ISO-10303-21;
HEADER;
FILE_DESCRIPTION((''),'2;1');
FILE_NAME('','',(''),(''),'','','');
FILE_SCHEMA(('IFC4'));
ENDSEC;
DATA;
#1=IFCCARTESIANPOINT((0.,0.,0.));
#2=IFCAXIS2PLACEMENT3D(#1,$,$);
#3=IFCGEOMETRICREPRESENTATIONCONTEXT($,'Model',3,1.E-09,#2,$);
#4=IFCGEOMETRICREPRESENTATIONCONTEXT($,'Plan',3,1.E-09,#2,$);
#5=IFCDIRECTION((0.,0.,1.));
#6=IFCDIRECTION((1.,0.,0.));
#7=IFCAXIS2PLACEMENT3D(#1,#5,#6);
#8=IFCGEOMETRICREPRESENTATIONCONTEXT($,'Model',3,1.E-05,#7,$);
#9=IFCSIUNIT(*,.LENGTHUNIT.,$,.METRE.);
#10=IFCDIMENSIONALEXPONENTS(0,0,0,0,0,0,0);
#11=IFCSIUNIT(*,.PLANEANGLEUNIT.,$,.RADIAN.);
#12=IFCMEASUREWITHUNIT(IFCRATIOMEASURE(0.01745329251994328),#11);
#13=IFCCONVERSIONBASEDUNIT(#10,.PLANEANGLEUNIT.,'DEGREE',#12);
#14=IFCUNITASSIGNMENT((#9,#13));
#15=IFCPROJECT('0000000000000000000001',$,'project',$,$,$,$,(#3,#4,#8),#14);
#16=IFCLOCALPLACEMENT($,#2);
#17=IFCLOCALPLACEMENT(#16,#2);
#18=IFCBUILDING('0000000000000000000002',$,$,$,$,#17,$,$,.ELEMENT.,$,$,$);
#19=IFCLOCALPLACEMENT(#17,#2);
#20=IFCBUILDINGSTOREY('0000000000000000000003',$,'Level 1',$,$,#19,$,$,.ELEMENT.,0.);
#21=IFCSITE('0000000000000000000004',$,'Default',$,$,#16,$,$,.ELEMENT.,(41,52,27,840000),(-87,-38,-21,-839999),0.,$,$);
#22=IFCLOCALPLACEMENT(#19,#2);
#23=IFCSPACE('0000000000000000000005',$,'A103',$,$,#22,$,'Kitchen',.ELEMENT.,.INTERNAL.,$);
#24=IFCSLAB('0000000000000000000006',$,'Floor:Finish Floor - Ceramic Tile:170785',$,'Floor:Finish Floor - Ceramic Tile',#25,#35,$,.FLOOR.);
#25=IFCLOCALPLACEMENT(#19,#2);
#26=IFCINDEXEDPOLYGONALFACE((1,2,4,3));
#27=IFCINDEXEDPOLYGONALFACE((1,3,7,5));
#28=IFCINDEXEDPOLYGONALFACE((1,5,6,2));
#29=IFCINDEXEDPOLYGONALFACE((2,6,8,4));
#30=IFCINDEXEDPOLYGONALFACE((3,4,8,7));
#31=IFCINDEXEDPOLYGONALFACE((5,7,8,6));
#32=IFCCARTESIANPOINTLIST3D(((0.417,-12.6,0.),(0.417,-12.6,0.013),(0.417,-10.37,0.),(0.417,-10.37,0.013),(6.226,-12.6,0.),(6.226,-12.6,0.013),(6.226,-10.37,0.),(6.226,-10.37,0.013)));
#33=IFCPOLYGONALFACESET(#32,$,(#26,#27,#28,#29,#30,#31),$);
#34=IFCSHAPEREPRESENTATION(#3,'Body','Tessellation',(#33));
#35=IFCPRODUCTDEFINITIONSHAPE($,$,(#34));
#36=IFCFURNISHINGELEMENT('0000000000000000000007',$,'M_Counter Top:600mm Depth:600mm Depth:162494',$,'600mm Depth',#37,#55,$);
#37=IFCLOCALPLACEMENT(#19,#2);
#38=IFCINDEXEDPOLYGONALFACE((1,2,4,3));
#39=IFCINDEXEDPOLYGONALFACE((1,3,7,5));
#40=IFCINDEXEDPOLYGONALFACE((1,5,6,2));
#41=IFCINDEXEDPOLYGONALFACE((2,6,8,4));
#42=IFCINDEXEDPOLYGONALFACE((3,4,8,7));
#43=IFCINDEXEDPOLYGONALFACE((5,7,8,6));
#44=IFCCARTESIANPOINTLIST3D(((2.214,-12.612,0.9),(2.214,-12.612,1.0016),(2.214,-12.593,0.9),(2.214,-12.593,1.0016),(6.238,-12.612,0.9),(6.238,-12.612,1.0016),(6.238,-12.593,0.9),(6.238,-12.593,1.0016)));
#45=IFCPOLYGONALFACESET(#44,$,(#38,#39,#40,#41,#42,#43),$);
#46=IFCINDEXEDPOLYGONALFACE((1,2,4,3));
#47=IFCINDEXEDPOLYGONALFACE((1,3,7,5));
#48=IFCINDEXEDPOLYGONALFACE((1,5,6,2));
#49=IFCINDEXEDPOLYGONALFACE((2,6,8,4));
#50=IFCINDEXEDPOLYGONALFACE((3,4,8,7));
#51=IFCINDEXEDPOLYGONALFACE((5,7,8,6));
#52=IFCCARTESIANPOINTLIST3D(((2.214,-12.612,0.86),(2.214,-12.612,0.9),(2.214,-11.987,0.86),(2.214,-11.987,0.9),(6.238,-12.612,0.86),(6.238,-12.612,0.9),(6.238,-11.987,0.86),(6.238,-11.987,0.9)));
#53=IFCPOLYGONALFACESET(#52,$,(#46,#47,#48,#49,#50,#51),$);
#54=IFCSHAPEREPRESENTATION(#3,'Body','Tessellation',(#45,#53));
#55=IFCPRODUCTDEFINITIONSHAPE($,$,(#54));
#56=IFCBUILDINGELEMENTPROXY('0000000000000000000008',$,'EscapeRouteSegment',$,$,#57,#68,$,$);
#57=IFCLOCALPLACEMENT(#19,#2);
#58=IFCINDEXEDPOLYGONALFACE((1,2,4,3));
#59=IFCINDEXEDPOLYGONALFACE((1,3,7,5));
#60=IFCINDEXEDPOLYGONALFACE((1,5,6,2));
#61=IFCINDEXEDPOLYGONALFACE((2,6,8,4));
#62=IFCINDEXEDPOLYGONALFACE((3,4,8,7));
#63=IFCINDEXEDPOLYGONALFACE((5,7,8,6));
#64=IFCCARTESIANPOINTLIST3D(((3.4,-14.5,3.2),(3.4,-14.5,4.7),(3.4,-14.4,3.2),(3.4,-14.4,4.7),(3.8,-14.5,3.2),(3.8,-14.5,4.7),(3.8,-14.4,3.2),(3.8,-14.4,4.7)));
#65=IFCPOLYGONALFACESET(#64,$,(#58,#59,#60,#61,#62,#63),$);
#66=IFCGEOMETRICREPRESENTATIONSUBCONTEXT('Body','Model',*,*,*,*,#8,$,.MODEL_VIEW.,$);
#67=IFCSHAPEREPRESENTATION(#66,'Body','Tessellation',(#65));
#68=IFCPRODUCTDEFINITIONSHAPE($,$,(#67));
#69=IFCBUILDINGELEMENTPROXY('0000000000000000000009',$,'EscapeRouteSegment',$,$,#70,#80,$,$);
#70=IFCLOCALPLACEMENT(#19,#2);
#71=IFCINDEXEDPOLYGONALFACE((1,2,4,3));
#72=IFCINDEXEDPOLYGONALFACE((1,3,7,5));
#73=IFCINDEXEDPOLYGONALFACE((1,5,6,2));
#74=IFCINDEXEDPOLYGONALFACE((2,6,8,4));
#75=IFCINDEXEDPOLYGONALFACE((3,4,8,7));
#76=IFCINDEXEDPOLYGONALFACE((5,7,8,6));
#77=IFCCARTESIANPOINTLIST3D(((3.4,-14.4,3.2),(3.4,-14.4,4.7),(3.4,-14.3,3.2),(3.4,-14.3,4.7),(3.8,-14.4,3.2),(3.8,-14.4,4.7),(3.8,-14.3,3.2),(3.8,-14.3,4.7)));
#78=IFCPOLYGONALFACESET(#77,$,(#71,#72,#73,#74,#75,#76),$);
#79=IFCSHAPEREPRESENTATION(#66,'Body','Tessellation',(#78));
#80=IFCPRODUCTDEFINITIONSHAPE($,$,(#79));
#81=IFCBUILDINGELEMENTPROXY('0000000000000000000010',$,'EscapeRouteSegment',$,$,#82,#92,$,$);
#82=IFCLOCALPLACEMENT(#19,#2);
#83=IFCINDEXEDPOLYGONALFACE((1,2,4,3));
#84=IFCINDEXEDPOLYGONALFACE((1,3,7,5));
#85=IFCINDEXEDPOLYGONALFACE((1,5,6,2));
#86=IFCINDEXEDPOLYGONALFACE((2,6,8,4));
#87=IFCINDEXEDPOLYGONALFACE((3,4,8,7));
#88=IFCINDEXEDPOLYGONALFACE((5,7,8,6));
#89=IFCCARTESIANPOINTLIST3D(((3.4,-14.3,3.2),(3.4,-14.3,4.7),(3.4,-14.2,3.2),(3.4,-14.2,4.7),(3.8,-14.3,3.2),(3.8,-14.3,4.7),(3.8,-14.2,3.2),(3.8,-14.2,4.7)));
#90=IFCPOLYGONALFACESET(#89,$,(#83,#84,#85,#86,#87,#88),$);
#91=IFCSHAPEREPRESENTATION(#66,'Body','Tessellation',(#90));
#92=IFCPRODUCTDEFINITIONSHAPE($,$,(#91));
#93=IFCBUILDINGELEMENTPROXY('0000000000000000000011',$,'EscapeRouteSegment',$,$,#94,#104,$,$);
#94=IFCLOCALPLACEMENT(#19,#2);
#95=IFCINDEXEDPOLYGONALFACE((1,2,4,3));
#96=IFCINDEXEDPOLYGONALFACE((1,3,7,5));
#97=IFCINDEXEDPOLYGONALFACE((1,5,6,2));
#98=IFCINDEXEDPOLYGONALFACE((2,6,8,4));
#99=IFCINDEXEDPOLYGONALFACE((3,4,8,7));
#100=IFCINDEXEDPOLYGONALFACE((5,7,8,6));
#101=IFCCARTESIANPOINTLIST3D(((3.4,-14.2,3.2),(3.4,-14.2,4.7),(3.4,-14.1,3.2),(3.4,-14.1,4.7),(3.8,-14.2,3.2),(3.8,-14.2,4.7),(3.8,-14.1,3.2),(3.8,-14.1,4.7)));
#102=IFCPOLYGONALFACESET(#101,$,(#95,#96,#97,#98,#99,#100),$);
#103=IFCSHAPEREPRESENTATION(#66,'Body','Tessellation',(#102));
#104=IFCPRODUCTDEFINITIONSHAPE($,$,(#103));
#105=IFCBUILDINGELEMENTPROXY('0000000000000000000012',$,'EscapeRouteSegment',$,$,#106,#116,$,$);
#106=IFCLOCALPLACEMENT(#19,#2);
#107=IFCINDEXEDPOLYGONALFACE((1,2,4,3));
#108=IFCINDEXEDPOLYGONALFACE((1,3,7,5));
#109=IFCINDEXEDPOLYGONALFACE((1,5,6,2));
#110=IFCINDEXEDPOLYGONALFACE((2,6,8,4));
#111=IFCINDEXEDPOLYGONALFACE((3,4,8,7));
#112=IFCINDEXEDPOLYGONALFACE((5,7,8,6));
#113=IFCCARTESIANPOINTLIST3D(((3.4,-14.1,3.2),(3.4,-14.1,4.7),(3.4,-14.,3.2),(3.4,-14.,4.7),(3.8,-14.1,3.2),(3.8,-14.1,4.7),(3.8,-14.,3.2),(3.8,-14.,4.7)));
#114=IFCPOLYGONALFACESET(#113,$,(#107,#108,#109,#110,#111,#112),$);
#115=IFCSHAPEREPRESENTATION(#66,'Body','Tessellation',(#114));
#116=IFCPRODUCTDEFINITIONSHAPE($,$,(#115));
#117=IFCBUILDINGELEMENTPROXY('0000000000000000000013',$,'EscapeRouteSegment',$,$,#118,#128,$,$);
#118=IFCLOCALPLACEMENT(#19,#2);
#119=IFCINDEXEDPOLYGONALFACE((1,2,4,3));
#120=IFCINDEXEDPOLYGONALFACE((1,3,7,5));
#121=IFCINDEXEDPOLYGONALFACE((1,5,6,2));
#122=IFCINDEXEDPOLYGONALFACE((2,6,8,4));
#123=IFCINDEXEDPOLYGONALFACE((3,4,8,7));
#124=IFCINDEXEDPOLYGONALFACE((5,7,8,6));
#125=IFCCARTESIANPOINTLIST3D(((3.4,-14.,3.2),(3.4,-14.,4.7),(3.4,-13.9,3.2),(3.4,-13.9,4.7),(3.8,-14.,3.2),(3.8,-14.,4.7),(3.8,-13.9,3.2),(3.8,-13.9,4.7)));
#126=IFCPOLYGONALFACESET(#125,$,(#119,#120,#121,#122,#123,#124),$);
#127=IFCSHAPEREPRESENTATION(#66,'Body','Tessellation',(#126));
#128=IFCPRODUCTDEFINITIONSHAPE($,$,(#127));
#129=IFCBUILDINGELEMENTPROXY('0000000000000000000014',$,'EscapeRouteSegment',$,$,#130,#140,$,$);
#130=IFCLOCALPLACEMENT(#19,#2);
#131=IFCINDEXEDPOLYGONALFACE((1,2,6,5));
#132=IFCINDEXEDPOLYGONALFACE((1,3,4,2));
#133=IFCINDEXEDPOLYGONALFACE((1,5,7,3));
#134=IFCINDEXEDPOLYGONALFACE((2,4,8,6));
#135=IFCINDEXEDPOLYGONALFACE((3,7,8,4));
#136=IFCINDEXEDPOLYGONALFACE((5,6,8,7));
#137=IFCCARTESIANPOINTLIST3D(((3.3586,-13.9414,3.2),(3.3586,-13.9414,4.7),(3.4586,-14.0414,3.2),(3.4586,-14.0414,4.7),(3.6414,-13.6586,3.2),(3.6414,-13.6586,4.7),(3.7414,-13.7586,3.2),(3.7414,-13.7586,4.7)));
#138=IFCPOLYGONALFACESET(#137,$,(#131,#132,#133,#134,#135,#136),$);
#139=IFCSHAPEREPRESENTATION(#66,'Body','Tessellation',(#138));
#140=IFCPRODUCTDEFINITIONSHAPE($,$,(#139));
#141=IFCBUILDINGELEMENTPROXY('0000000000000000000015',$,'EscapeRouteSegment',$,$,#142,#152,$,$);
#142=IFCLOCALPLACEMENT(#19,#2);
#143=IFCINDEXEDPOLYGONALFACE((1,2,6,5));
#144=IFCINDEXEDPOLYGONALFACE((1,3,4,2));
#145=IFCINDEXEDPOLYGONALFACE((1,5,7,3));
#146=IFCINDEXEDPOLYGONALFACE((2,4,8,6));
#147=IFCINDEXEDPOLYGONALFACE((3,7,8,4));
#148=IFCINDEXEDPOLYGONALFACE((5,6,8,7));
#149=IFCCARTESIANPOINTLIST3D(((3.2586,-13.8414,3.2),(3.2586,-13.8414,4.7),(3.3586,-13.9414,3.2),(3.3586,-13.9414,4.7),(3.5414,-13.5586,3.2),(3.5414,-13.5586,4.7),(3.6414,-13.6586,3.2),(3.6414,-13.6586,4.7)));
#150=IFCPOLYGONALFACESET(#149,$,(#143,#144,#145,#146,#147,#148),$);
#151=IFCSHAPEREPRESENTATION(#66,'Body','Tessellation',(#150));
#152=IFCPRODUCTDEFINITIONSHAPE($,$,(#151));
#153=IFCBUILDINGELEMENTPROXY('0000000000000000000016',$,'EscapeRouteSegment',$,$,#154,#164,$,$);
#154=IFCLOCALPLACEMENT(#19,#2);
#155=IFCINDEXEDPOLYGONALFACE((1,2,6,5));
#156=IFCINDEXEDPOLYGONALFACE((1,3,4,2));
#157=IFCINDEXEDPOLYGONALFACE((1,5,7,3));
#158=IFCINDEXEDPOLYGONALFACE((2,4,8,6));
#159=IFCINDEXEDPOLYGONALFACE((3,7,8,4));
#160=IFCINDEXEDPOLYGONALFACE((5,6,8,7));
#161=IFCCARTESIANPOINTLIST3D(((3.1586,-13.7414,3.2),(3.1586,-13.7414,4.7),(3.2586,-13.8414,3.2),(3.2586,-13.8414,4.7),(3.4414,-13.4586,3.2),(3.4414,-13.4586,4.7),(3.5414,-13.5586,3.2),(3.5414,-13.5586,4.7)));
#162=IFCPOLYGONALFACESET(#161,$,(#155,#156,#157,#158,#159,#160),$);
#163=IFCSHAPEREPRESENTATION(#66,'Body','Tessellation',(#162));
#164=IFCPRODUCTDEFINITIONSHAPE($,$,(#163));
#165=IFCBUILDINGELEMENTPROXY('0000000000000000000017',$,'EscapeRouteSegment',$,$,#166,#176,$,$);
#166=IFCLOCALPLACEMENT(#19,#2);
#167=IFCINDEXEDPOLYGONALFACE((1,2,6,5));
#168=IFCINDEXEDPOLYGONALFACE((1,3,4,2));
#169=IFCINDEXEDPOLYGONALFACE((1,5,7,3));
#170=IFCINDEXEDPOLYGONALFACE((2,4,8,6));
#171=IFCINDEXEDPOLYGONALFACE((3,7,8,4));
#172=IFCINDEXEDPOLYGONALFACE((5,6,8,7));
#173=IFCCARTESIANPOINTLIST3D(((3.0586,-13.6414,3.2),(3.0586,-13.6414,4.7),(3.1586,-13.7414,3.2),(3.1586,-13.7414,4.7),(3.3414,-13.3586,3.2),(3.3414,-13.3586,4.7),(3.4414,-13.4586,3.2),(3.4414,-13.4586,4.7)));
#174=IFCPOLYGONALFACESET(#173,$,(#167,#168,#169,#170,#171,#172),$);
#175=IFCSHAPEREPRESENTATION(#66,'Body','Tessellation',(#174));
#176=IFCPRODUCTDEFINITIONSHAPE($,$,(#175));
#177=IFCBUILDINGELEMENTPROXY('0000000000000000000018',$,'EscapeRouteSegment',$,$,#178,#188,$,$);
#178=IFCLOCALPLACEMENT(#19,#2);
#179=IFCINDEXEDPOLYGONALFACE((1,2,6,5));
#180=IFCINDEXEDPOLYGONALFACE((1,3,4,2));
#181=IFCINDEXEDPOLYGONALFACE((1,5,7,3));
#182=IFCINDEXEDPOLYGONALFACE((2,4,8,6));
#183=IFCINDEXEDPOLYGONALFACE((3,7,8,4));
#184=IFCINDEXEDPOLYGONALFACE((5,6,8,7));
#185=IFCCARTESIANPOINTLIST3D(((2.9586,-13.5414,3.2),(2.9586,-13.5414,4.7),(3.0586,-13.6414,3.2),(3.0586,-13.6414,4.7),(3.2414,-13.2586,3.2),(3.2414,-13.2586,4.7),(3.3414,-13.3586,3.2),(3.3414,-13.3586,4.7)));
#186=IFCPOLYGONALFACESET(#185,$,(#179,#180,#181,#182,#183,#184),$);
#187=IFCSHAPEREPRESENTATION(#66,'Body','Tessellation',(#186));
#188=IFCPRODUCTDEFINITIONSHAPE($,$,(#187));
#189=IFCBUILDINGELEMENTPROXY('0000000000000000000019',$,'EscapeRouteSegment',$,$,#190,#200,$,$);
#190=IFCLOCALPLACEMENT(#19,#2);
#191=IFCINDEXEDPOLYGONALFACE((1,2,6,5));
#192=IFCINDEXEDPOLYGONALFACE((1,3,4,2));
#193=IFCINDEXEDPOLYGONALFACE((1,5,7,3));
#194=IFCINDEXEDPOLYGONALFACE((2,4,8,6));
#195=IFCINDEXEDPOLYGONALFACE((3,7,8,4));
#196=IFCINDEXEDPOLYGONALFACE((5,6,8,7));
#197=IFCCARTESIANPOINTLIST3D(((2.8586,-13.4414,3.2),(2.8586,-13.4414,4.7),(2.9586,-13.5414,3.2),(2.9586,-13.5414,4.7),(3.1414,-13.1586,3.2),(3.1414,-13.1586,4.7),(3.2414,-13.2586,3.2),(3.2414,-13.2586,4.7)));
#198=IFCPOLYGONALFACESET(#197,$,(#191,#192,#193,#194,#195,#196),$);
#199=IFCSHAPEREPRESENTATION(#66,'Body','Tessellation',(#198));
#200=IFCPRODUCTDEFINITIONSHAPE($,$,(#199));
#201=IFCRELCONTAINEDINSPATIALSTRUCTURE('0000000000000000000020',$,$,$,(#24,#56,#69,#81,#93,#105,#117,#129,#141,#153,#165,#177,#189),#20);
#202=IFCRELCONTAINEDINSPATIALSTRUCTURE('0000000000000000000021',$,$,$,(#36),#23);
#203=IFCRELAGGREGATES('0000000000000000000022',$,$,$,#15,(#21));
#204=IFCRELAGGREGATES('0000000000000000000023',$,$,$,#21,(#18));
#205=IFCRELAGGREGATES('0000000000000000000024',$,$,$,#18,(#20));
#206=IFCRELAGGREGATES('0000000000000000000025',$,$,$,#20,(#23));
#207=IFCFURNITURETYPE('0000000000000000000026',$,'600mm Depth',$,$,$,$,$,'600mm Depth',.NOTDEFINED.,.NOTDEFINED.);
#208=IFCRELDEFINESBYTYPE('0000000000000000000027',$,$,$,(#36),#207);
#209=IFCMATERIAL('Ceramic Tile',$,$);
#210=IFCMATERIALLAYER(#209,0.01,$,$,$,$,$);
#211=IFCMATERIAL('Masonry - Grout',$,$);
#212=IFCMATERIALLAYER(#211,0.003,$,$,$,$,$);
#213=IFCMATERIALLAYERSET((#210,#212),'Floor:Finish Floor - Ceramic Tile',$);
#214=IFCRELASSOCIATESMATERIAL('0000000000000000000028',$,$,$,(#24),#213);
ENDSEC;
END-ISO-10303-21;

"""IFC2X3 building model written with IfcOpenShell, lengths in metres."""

from ifc_helpers import new_model, entity, si_unit, converted_unit, frame, frame_2d, origin, origin_with_axes, origin_2d_with_axis, place, context, subcontext, project, spatial, polyline, rectangle, outline, extrude, source, transform, mapped, material, layer, layer_set, layer_usage, type_object, type_shapes, element, save


model = new_model("IFC2X3")

# Units and contexts
model_context_1 = context("Model", 3, precision=1e-09, world=origin())
plan_context = context("Plan", 3, precision=1e-09, world=origin())
model_context_2 = context("Model", 3, precision=1e-05, world=origin_with_axes())
body_context = subcontext(model_context_2, "Body", "Model", "MODEL_VIEW")
ifc_project = project(units=[si_unit("LENGTHUNIT", "METRE"), converted_unit("PLANEANGLEUNIT", "DEGREE", entity("IfcRatioMeasure", 0.01745329251994328), si_unit("PLANEANGLEUNIT", "RADIAN"), dimensions=[0, 0, 0, 0, 0, 0, 0])], contexts=[model_context_1, plan_context, model_context_2])

# Site, building, storey
site_placement = place(None, origin())
site = spatial("IfcSite", under=ifc_project, at=site_placement, Name="Default", CompositionType="ELEMENT", RefLatitude=(41, 52, 27, 840000), RefLongitude=(-87, -38, -21, -839999), RefElevation=0.0)
building_placement = place(site_placement, origin())
building = spatial("IfcBuilding", under=site, at=building_placement, CompositionType="ELEMENT")
storey_placement = place(building_placement, origin())
storey = spatial("IfcBuildingStorey", under=building, at=storey_placement, Name="Level 1", CompositionType="ELEMENT", Elevation=0.0)

# Slab
ifc_material_1 = material(Name="Ceramic Tile")
ifc_layer_1 = layer(ifc_material_1, 0.01)
ifc_material_2 = material(Name="Masonry - Grout")
ifc_layer_2 = layer(ifc_material_2, 0.003)
ifc_layer_set = layer_set([ifc_layer_1, ifc_layer_2], Name="Floor:Finish Floor - Ceramic Tile")
ifc_layer_usage = layer_usage(ifc_layer_set, "AXIS3", "POSITIVE", 0.0)
slab_placement = place(storey_placement, frame((0.417, -12.6, 0.0)))
element("IfcSlab", 1, at=slab_placement, inside=storey, material=ifc_layer_usage, Name="Floor:Finish Floor - Ceramic Tile:170785", ObjectType="Floor:Finish Floor - Ceramic Tile", PredefinedType="FLOOR", context=model_context_1, shape_type="SweptSolid", body=[
    extrude(rectangle(XDim=5.809, YDim=2.23, at=frame_2d((0.0, 0.0), x_axis=(-1.0, 0.0))), frame((2.9045, 1.115, 0.013), z_axis=(0.0, 0.0, -1.0), x_axis=(-1.0, 0.0, 0.0)), (0.0, 0.0, 1.0), 0.013),
])

# Shared definitions
space_1_placement = place(storey_placement, origin())
space_1 = spatial("IfcSpace", under=storey, at=space_1_placement, Name="A103", LongName="Kitchen", CompositionType="ELEMENT", InteriorOrExteriorSpace="INTERNAL")

# Furnishing element
furniture_type_1 = type_object("IfcFurnitureType", Name="600mm Depth", ElementType="600mm Depth", AssemblyPlace="NOTDEFINED")
shared_shape_1 = source(origin(), model_context_1, "Body", "SweptSolid", [
    extrude(rectangle(XDim=0.0191, YDim=4.024, at=origin_2d_with_axis()), frame((0.8115, -0.0095, 0.9), z_axis=(0.0, 0.0, 1.0), x_axis=(0.0, -1.0, 0.0)), (0.0, 0.0, 1.0), 0.1016),
    extrude(rectangle(XDim=4.024, YDim=0.625, at=origin_2d_with_axis()), frame((0.8115, -0.3125, 0.86), z_axis=(0.0, 0.0, 1.0), x_axis=(-1.0, 0.0, 0.0)), (0.0, 0.0, 1.0), 0.04),
])
type_shapes(furniture_type_1, [shared_shape_1])
furnishing_1_placement = place(space_1_placement, frame((5.0375, -12.612, 0.0), z_axis=(0.0, 0.0, 1.0), x_axis=(-1.0, 0.0, 0.0)))
element("IfcFurnishingElement", 2, at=furnishing_1_placement, inside=space_1, type_object=furniture_type_1, Name="M_Counter Top:600mm Depth:600mm Depth:162494", ObjectType="600mm Depth", context=model_context_1, shape_type="MappedRepresentation", body=[
    mapped(shared_shape_1, transform((0.0, 0.0, 0.0), scale=1.0)),
])

# Building element proxies
proxy_1_placement = place(storey_placement, frame((3.6, -14.5, 3.2), z_axis=(0.0, 0.0, 1.0), x_axis=(0.0, 1.0, 0.0)))
element("IfcBuildingElementProxy", 3, at=proxy_1_placement, inside=storey, Name="EscapeRouteSegment", context=body_context, shape_type="SweptSolid", body=[
    extrude(outline(polyline([(0.0, -0.2), (0.0, 0.2), (0.1, 0.2), (0.1, -0.2), (0.0, -0.2)])), origin_with_axes(), (0.0, 0.0, 1.0), 1.5),
])
proxy_2_placement = place(storey_placement, frame((3.6, -14.4, 3.2), z_axis=(0.0, 0.0, 1.0), x_axis=(0.0, 1.0, 0.0)))
element("IfcBuildingElementProxy", 4, at=proxy_2_placement, inside=storey, Name="EscapeRouteSegment", context=body_context, shape_type="SweptSolid", body=[
    extrude(outline(polyline([(0.0, -0.2), (0.0, 0.2), (0.1, 0.2), (0.1, -0.2), (0.0, -0.2)])), origin_with_axes(), (0.0, 0.0, 1.0), 1.5),
])
proxy_3_placement = place(storey_placement, frame((3.6, -14.3, 3.2), z_axis=(0.0, 0.0, 1.0), x_axis=(0.0, 1.0, 0.0)))
element("IfcBuildingElementProxy", 5, at=proxy_3_placement, inside=storey, Name="EscapeRouteSegment", context=body_context, shape_type="SweptSolid", body=[
    extrude(outline(polyline([(0.0, -0.2), (0.0, 0.2), (0.1, 0.2), (0.1, -0.2), (0.0, -0.2)])), origin_with_axes(), (0.0, 0.0, 1.0), 1.5),
])
proxy_4_placement = place(storey_placement, frame((3.6, -14.2, 3.2), z_axis=(0.0, 0.0, 1.0), x_axis=(0.0, 1.0, 0.0)))
element("IfcBuildingElementProxy", 6, at=proxy_4_placement, inside=storey, Name="EscapeRouteSegment", context=body_context, shape_type="SweptSolid", body=[
    extrude(outline(polyline([(0.0, -0.2), (0.0, 0.2), (0.1, 0.2), (0.1, -0.2), (0.0, -0.2)])), origin_with_axes(), (0.0, 0.0, 1.0), 1.5),
])
for number, where, z_axis, x_axis, name in (
    (7, (3.6, -14.1, 3.2), (0.0, 0.0, 1.0), (0.0, 1.0, 0.0), "EscapeRouteSegment"),
    (8, (3.6, -14.0, 3.2), (0.0, 0.0, 1.0), (0.0, 1.0, 0.0), "EscapeRouteSegment"),
):
    element("IfcBuildingElementProxy", number, at=place(storey_placement, frame(where, z_axis=z_axis, x_axis=x_axis)), inside=storey, Name=name, context=body_context, shape_type="SweptSolid", body=[
        extrude(outline(polyline([(0.0, -0.2), (0.0, 0.2), (0.1, 0.2), (0.1, -0.2), (0.0, -0.2)])), origin_with_axes(), (0.0, 0.0, 1.0), 1.5),
    ])
proxy_5_placement = place(storey_placement, frame((3.6, -13.9, 3.2), z_axis=(0.0, 0.0, 1.0), x_axis=(-0.707108, 0.707105, 0.0)))
element("IfcBuildingElementProxy", 9, at=proxy_5_placement, inside=storey, Name="EscapeRouteSegment", context=body_context, shape_type="SweptSolid", body=[
    extrude(outline(polyline([(0.0, -0.2), (0.0, 0.2), (0.1414, 0.2), (0.1414, -0.2), (0.0, -0.2)])), origin_with_axes(), (0.0, 0.0, 1.0), 1.5),
])
proxy_6_placement = place(storey_placement, frame((3.5, -13.8, 3.2), z_axis=(0.0, 0.0, 1.0), x_axis=(-0.707105, 0.707108, 0.0)))
element("IfcBuildingElementProxy", 10, at=proxy_6_placement, inside=storey, Name="EscapeRouteSegment", context=body_context, shape_type="SweptSolid", body=[
    extrude(outline(polyline([(0.0, -0.2), (0.0, 0.2), (0.1414, 0.2), (0.1414, -0.2), (0.0, -0.2)])), origin_with_axes(), (0.0, 0.0, 1.0), 1.5),
])
proxy_7_placement = place(storey_placement, frame((3.4, -13.7, 3.2), z_axis=(0.0, 0.0, 1.0), x_axis=(-0.707109, 0.707104, 0.0)))
element("IfcBuildingElementProxy", 11, at=proxy_7_placement, inside=storey, Name="EscapeRouteSegment", context=body_context, shape_type="SweptSolid", body=[
    extrude(outline(polyline([(0.0, -0.2), (0.0, 0.2), (0.1414, 0.2), (0.1414, -0.2), (0.0, -0.2)])), origin_with_axes(), (0.0, 0.0, 1.0), 1.5),
])
proxy_8_placement = place(storey_placement, frame((3.3, -13.6, 3.2), z_axis=(0.0, 0.0, 1.0), x_axis=(-0.707105, 0.707108, 0.0)))
element("IfcBuildingElementProxy", 12, at=proxy_8_placement, inside=storey, Name="EscapeRouteSegment", context=body_context, shape_type="SweptSolid", body=[
    extrude(outline(polyline([(0.0, -0.2), (0.0, 0.2), (0.1414, 0.2), (0.1414, -0.2), (0.0, -0.2)])), origin_with_axes(), (0.0, 0.0, 1.0), 1.5),
])
proxy_9_placement = place(storey_placement, frame((3.2, -13.5, 3.2), z_axis=(0.0, 0.0, 1.0), x_axis=(-0.707106, 0.707108, 0.0)))
element("IfcBuildingElementProxy", 13, at=proxy_9_placement, inside=storey, Name="EscapeRouteSegment", context=body_context, shape_type="SweptSolid", body=[
    extrude(outline(polyline([(0.0, -0.2), (0.0, 0.2), (0.1414, 0.2), (0.1414, -0.2), (0.0, -0.2)])), origin_with_axes(), (0.0, 0.0, 1.0), 1.5),
])
proxy_10_placement = place(storey_placement, frame((3.1, -13.4, 3.2), z_axis=(0.0, 0.0, 1.0), x_axis=(-0.707108, 0.707105, 0.0)))
element("IfcBuildingElementProxy", 14, at=proxy_10_placement, inside=storey, Name="EscapeRouteSegment", context=body_context, shape_type="SweptSolid", body=[
    extrude(outline(polyline([(0.0, -0.2), (0.0, 0.2), (0.1414, 0.2), (0.1414, -0.2), (0.0, -0.2)])), origin_with_axes(), (0.0, 0.0, 1.0), 1.5),
])

save(model, "model.ifc")
